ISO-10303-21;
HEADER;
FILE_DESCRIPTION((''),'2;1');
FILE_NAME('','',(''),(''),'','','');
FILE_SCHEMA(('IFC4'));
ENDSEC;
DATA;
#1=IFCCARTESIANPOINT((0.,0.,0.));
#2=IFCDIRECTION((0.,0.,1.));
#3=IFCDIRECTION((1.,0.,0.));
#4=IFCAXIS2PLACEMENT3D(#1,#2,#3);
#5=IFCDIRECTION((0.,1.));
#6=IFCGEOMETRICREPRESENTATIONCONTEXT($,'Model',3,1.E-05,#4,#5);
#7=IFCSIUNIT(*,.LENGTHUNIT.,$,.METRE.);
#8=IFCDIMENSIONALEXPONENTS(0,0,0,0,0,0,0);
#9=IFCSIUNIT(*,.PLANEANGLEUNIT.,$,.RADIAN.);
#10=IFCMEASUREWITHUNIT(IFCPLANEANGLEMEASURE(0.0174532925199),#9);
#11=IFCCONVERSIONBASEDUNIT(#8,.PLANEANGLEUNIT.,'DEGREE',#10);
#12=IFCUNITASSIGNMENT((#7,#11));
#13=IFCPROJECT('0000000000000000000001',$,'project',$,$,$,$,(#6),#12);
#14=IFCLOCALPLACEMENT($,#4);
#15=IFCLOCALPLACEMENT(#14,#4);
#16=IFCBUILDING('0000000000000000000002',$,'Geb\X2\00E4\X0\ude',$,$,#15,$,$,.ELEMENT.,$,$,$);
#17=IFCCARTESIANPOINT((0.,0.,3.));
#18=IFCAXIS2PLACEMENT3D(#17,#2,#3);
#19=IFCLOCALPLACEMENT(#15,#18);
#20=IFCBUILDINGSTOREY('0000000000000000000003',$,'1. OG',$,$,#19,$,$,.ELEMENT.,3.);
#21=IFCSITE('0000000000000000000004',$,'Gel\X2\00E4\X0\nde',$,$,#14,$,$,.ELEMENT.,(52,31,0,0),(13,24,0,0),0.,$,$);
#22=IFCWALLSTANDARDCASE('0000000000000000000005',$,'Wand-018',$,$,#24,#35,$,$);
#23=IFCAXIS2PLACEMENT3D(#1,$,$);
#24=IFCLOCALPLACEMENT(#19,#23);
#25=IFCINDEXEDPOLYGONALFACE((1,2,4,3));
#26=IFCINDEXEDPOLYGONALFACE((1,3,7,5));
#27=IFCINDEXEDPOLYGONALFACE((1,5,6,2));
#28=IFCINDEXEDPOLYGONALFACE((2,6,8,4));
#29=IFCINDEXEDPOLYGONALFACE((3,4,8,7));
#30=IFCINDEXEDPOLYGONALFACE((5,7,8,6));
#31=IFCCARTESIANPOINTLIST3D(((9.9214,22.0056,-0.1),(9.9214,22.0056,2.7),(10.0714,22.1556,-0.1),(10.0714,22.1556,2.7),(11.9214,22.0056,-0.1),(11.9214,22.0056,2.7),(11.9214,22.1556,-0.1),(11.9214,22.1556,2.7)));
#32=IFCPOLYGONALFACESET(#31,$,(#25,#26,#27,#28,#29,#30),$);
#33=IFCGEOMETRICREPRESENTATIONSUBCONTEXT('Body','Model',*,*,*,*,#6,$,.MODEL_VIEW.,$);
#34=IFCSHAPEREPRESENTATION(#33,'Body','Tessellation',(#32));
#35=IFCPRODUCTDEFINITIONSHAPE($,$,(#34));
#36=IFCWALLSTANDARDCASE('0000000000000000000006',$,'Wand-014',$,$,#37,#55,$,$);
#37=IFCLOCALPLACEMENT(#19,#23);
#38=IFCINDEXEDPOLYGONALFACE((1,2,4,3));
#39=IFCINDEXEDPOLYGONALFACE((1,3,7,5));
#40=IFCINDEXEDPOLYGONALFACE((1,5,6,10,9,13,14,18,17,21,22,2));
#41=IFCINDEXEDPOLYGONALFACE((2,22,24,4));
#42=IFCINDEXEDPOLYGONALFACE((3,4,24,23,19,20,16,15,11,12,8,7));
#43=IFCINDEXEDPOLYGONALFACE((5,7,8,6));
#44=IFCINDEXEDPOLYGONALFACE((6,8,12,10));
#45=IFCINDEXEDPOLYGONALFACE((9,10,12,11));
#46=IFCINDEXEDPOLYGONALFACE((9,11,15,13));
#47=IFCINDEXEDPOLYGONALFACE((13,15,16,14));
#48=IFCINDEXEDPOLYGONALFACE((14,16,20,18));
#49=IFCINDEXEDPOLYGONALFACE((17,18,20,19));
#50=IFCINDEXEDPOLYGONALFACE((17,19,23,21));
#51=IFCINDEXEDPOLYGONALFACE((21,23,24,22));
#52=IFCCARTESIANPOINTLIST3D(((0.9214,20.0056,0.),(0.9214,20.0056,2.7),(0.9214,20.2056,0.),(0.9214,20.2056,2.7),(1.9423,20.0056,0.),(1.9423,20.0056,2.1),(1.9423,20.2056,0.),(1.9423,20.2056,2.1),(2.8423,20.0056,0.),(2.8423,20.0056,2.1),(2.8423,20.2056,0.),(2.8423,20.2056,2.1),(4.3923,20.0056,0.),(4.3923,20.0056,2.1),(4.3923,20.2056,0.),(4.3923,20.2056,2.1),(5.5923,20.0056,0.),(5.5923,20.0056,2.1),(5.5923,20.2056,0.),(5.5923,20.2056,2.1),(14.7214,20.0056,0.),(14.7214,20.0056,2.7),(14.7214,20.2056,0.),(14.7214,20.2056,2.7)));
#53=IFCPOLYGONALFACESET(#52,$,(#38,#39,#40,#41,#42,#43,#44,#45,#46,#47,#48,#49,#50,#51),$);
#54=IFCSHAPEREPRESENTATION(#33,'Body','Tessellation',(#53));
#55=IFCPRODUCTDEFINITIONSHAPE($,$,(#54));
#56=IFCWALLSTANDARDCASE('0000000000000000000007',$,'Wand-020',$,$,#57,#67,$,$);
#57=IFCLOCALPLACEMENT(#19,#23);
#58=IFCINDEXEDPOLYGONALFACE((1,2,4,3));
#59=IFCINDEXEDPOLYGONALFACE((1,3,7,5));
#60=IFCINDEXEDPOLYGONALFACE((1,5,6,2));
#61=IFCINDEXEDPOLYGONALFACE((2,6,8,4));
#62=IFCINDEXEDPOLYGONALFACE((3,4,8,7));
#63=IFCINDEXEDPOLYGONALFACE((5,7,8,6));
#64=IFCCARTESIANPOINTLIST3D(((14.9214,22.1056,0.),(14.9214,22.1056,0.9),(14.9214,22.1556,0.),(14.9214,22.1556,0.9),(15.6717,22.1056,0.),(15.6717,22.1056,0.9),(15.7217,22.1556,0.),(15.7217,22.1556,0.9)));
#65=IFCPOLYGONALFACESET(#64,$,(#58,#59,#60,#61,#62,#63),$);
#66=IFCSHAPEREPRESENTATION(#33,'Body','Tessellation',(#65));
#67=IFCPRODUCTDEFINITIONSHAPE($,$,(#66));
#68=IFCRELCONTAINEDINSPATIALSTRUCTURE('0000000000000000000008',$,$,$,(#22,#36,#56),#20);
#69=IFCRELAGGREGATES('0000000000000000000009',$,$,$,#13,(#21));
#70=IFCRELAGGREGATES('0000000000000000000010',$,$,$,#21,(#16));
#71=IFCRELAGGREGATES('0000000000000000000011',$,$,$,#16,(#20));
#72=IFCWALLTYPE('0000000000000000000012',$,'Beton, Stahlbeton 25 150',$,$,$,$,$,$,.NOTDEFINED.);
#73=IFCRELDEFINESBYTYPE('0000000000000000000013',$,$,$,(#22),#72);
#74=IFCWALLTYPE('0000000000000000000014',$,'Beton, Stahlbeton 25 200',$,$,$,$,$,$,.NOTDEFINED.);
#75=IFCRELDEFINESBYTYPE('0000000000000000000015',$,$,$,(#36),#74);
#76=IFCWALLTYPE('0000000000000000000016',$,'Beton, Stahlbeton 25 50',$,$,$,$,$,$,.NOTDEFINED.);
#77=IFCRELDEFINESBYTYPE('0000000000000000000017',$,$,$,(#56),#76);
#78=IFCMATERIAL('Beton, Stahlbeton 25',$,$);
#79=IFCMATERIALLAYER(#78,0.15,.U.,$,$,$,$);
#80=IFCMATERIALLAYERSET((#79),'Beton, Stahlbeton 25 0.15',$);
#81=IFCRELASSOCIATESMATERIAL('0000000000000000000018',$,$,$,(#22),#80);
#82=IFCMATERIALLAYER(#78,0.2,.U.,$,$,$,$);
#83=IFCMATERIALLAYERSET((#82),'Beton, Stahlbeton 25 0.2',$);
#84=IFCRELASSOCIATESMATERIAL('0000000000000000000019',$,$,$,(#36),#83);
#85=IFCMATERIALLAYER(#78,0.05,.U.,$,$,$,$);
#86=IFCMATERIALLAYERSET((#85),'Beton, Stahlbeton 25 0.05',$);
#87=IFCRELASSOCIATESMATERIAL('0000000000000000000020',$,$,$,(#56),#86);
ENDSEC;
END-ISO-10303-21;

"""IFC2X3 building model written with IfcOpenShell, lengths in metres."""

from ifc_helpers import new_model, entity, si_unit, converted_unit, direction, frame, origin_with_axes, origin_2d_with_axis, place, context, subcontext, project, spatial, polyline, rectangle, outline, extrude, material, layer, layer_set, layer_usage, type_object, element, save


model = new_model("IFC2X3")

# Units and contexts
model_context = context("Model", 3, precision=1e-05, world=origin_with_axes(), true_north=direction((0.0, 1.0)))
body_context = subcontext(model_context, "Body", "Model", "MODEL_VIEW")
ifc_project = project(units=[si_unit("LENGTHUNIT", "METRE"), converted_unit("PLANEANGLEUNIT", "DEGREE", entity("IfcPlaneAngleMeasure", 0.0174532925199), si_unit("PLANEANGLEUNIT", "RADIAN"), dimensions=[0, 0, 0, 0, 0, 0, 0])], contexts=[model_context])

# Site, building, storey
site_placement = place(None, origin_with_axes())
site = spatial("IfcSite", under=ifc_project, at=site_placement, Name="Gelände", CompositionType="ELEMENT", RefLatitude=(52, 31, 0, 0), RefLongitude=(13, 24, 0, 0), RefElevation=0.0)
building_placement = place(site_placement, origin_with_axes())
building = spatial("IfcBuilding", under=site, at=building_placement, Name="Gebäude", CompositionType="ELEMENT")
storey_placement = place(building_placement, frame((0.0, 0.0, 3.0), z_axis=(0.0, 0.0, 1.0), x_axis=(1.0, 0.0, 0.0)))
storey = spatial("IfcBuildingStorey", under=building, at=storey_placement, Name="1. OG", CompositionType="ELEMENT", Elevation=3.0)

# Wall
ifc_material = material(Name="Beton, Stahlbeton 25")
ifc_layer_1 = layer(ifc_material, 0.15, ventilated="UNKNOWN")
ifc_layer_set_1 = layer_set([ifc_layer_1], Name="Beton, Stahlbeton 25 0.15")
ifc_layer_usage_1 = layer_usage(ifc_layer_set_1, "AXIS2", "POSITIVE", 0.0)
wall_type_1 = type_object("IfcWallType", Name="Beton, Stahlbeton 25 150", PredefinedType="NOTDEFINED")
wall_1_placement = place(storey_placement, frame((11.9214, 22.1556, -0.1), z_axis=(0.0, 0.0, 1.0), x_axis=(-1.0, 0.0, 0.0)))
element("IfcWallStandardCase", 1, at=wall_1_placement, inside=storey, type_object=wall_type_1, material=ifc_layer_usage_1, Name="Wand-018", context=body_context, shape_type="SweptSolid", body=[
    extrude(outline(polyline([(0.0, 0.0), (1.85, 0.0), (2.0, 0.15), (0.0, 0.15), (0.0, 0.0)])), origin_with_axes(), (0.0, 0.0, 1.0), 2.8),
])

# Wall, openings
wall_type_2 = type_object("IfcWallType", Name="Beton, Stahlbeton 25 200", PredefinedType="NOTDEFINED")
ifc_layer_2 = layer(ifc_material, 0.2, ventilated="UNKNOWN")
ifc_layer_set_2 = layer_set([ifc_layer_2], Name="Beton, Stahlbeton 25 0.2")
ifc_layer_usage_2 = layer_usage(ifc_layer_set_2, "AXIS2", "POSITIVE", 0.0)
wall_2_placement = place(storey_placement, frame((14.9214, 20.2056, 0.0), z_axis=(0.0, 0.0, 1.0), x_axis=(-1.0, 0.0, 0.0)))
wall_2 = element("IfcWallStandardCase", 2, at=wall_2_placement, inside=storey, type_object=wall_type_2, material=ifc_layer_usage_2, Name="Wand-014", context=body_context, shape_type="SweptSolid", body=[
    extrude(outline(polyline([(0.2, 0.0), (14.0, 0.0), (14.0, 0.2), (0.2, 0.2), (0.2, 0.0)])), origin_with_axes(), (0.0, 0.0, 1.0), 2.7),
])
opening_1_placement = place(wall_2_placement, frame((12.5292, 0.0, 0.0), z_axis=(0.0, 0.0, 1.0), x_axis=(1.0, 0.0, 0.0)))
element("IfcOpeningElement", 3, at=opening_1_placement, cuts=wall_2, context=body_context, shape_type="SweptSolid", body=[
    extrude(rectangle(XDim=0.9, YDim=2.1, at=origin_2d_with_axis()), frame((0.0, 0.4, 1.05), z_axis=(0.0, -1.0, 0.0), x_axis=(1.0, 0.0, 0.0)), (0.0, 0.0, 1.0), 0.2),
    extrude(rectangle(XDim=0.9, YDim=2.1, at=origin_2d_with_axis()), frame((0.0, 0.0, 1.05), z_axis=(0.0, 1.0, 0.0), x_axis=(1.0, 0.0, 0.0)), (0.0, 0.0, 1.0), 0.2),
])
opening_2_placement = place(wall_2_placement, frame((9.9292, 0.0, 0.0), z_axis=(0.0, 0.0, 1.0), x_axis=(1.0, 0.0, 0.0)))
element("IfcOpeningElement", 4, at=opening_2_placement, cuts=wall_2, context=body_context, shape_type="SweptSolid", body=[
    extrude(rectangle(XDim=1.2, YDim=2.1, at=origin_2d_with_axis()), frame((0.0, 0.4, 1.05), z_axis=(0.0, -1.0, 0.0), x_axis=(1.0, 0.0, 0.0)), (0.0, 0.0, 1.0), 0.2),
    extrude(rectangle(XDim=1.2, YDim=2.1, at=origin_2d_with_axis()), frame((0.0, 0.0, 1.05), z_axis=(0.0, 1.0, 0.0), x_axis=(1.0, 0.0, 0.0)), (0.0, 0.0, 1.0), 0.2),
])

# Wall
ifc_layer_3 = layer(ifc_material, 0.05, ventilated="UNKNOWN")
ifc_layer_set_3 = layer_set([ifc_layer_3], Name="Beton, Stahlbeton 25 0.05")
ifc_layer_usage_3 = layer_usage(ifc_layer_set_3, "AXIS2", "NEGATIVE", 0.0)
wall_type_3 = type_object("IfcWallType", Name="Beton, Stahlbeton 25 50", PredefinedType="NOTDEFINED")
wall_3_placement = place(storey_placement, frame((14.9214, 22.1556, 0.0), z_axis=(0.0, 0.0, 1.0), x_axis=(1.0, 0.0, 0.0)))
element("IfcWallStandardCase", 5, at=wall_3_placement, inside=storey, type_object=wall_type_3, material=ifc_layer_usage_3, Name="Wand-020", context=body_context, shape_type="SweptSolid", body=[
    extrude(outline(polyline([(0.0, -0.05), (0.7503, -0.05), (0.8003, 0.0), (0.0, 0.0), (0.0, -0.05)])), origin_with_axes(), (0.0, 0.0, 1.0), 0.9),
])

save(model, "model.ifc")
